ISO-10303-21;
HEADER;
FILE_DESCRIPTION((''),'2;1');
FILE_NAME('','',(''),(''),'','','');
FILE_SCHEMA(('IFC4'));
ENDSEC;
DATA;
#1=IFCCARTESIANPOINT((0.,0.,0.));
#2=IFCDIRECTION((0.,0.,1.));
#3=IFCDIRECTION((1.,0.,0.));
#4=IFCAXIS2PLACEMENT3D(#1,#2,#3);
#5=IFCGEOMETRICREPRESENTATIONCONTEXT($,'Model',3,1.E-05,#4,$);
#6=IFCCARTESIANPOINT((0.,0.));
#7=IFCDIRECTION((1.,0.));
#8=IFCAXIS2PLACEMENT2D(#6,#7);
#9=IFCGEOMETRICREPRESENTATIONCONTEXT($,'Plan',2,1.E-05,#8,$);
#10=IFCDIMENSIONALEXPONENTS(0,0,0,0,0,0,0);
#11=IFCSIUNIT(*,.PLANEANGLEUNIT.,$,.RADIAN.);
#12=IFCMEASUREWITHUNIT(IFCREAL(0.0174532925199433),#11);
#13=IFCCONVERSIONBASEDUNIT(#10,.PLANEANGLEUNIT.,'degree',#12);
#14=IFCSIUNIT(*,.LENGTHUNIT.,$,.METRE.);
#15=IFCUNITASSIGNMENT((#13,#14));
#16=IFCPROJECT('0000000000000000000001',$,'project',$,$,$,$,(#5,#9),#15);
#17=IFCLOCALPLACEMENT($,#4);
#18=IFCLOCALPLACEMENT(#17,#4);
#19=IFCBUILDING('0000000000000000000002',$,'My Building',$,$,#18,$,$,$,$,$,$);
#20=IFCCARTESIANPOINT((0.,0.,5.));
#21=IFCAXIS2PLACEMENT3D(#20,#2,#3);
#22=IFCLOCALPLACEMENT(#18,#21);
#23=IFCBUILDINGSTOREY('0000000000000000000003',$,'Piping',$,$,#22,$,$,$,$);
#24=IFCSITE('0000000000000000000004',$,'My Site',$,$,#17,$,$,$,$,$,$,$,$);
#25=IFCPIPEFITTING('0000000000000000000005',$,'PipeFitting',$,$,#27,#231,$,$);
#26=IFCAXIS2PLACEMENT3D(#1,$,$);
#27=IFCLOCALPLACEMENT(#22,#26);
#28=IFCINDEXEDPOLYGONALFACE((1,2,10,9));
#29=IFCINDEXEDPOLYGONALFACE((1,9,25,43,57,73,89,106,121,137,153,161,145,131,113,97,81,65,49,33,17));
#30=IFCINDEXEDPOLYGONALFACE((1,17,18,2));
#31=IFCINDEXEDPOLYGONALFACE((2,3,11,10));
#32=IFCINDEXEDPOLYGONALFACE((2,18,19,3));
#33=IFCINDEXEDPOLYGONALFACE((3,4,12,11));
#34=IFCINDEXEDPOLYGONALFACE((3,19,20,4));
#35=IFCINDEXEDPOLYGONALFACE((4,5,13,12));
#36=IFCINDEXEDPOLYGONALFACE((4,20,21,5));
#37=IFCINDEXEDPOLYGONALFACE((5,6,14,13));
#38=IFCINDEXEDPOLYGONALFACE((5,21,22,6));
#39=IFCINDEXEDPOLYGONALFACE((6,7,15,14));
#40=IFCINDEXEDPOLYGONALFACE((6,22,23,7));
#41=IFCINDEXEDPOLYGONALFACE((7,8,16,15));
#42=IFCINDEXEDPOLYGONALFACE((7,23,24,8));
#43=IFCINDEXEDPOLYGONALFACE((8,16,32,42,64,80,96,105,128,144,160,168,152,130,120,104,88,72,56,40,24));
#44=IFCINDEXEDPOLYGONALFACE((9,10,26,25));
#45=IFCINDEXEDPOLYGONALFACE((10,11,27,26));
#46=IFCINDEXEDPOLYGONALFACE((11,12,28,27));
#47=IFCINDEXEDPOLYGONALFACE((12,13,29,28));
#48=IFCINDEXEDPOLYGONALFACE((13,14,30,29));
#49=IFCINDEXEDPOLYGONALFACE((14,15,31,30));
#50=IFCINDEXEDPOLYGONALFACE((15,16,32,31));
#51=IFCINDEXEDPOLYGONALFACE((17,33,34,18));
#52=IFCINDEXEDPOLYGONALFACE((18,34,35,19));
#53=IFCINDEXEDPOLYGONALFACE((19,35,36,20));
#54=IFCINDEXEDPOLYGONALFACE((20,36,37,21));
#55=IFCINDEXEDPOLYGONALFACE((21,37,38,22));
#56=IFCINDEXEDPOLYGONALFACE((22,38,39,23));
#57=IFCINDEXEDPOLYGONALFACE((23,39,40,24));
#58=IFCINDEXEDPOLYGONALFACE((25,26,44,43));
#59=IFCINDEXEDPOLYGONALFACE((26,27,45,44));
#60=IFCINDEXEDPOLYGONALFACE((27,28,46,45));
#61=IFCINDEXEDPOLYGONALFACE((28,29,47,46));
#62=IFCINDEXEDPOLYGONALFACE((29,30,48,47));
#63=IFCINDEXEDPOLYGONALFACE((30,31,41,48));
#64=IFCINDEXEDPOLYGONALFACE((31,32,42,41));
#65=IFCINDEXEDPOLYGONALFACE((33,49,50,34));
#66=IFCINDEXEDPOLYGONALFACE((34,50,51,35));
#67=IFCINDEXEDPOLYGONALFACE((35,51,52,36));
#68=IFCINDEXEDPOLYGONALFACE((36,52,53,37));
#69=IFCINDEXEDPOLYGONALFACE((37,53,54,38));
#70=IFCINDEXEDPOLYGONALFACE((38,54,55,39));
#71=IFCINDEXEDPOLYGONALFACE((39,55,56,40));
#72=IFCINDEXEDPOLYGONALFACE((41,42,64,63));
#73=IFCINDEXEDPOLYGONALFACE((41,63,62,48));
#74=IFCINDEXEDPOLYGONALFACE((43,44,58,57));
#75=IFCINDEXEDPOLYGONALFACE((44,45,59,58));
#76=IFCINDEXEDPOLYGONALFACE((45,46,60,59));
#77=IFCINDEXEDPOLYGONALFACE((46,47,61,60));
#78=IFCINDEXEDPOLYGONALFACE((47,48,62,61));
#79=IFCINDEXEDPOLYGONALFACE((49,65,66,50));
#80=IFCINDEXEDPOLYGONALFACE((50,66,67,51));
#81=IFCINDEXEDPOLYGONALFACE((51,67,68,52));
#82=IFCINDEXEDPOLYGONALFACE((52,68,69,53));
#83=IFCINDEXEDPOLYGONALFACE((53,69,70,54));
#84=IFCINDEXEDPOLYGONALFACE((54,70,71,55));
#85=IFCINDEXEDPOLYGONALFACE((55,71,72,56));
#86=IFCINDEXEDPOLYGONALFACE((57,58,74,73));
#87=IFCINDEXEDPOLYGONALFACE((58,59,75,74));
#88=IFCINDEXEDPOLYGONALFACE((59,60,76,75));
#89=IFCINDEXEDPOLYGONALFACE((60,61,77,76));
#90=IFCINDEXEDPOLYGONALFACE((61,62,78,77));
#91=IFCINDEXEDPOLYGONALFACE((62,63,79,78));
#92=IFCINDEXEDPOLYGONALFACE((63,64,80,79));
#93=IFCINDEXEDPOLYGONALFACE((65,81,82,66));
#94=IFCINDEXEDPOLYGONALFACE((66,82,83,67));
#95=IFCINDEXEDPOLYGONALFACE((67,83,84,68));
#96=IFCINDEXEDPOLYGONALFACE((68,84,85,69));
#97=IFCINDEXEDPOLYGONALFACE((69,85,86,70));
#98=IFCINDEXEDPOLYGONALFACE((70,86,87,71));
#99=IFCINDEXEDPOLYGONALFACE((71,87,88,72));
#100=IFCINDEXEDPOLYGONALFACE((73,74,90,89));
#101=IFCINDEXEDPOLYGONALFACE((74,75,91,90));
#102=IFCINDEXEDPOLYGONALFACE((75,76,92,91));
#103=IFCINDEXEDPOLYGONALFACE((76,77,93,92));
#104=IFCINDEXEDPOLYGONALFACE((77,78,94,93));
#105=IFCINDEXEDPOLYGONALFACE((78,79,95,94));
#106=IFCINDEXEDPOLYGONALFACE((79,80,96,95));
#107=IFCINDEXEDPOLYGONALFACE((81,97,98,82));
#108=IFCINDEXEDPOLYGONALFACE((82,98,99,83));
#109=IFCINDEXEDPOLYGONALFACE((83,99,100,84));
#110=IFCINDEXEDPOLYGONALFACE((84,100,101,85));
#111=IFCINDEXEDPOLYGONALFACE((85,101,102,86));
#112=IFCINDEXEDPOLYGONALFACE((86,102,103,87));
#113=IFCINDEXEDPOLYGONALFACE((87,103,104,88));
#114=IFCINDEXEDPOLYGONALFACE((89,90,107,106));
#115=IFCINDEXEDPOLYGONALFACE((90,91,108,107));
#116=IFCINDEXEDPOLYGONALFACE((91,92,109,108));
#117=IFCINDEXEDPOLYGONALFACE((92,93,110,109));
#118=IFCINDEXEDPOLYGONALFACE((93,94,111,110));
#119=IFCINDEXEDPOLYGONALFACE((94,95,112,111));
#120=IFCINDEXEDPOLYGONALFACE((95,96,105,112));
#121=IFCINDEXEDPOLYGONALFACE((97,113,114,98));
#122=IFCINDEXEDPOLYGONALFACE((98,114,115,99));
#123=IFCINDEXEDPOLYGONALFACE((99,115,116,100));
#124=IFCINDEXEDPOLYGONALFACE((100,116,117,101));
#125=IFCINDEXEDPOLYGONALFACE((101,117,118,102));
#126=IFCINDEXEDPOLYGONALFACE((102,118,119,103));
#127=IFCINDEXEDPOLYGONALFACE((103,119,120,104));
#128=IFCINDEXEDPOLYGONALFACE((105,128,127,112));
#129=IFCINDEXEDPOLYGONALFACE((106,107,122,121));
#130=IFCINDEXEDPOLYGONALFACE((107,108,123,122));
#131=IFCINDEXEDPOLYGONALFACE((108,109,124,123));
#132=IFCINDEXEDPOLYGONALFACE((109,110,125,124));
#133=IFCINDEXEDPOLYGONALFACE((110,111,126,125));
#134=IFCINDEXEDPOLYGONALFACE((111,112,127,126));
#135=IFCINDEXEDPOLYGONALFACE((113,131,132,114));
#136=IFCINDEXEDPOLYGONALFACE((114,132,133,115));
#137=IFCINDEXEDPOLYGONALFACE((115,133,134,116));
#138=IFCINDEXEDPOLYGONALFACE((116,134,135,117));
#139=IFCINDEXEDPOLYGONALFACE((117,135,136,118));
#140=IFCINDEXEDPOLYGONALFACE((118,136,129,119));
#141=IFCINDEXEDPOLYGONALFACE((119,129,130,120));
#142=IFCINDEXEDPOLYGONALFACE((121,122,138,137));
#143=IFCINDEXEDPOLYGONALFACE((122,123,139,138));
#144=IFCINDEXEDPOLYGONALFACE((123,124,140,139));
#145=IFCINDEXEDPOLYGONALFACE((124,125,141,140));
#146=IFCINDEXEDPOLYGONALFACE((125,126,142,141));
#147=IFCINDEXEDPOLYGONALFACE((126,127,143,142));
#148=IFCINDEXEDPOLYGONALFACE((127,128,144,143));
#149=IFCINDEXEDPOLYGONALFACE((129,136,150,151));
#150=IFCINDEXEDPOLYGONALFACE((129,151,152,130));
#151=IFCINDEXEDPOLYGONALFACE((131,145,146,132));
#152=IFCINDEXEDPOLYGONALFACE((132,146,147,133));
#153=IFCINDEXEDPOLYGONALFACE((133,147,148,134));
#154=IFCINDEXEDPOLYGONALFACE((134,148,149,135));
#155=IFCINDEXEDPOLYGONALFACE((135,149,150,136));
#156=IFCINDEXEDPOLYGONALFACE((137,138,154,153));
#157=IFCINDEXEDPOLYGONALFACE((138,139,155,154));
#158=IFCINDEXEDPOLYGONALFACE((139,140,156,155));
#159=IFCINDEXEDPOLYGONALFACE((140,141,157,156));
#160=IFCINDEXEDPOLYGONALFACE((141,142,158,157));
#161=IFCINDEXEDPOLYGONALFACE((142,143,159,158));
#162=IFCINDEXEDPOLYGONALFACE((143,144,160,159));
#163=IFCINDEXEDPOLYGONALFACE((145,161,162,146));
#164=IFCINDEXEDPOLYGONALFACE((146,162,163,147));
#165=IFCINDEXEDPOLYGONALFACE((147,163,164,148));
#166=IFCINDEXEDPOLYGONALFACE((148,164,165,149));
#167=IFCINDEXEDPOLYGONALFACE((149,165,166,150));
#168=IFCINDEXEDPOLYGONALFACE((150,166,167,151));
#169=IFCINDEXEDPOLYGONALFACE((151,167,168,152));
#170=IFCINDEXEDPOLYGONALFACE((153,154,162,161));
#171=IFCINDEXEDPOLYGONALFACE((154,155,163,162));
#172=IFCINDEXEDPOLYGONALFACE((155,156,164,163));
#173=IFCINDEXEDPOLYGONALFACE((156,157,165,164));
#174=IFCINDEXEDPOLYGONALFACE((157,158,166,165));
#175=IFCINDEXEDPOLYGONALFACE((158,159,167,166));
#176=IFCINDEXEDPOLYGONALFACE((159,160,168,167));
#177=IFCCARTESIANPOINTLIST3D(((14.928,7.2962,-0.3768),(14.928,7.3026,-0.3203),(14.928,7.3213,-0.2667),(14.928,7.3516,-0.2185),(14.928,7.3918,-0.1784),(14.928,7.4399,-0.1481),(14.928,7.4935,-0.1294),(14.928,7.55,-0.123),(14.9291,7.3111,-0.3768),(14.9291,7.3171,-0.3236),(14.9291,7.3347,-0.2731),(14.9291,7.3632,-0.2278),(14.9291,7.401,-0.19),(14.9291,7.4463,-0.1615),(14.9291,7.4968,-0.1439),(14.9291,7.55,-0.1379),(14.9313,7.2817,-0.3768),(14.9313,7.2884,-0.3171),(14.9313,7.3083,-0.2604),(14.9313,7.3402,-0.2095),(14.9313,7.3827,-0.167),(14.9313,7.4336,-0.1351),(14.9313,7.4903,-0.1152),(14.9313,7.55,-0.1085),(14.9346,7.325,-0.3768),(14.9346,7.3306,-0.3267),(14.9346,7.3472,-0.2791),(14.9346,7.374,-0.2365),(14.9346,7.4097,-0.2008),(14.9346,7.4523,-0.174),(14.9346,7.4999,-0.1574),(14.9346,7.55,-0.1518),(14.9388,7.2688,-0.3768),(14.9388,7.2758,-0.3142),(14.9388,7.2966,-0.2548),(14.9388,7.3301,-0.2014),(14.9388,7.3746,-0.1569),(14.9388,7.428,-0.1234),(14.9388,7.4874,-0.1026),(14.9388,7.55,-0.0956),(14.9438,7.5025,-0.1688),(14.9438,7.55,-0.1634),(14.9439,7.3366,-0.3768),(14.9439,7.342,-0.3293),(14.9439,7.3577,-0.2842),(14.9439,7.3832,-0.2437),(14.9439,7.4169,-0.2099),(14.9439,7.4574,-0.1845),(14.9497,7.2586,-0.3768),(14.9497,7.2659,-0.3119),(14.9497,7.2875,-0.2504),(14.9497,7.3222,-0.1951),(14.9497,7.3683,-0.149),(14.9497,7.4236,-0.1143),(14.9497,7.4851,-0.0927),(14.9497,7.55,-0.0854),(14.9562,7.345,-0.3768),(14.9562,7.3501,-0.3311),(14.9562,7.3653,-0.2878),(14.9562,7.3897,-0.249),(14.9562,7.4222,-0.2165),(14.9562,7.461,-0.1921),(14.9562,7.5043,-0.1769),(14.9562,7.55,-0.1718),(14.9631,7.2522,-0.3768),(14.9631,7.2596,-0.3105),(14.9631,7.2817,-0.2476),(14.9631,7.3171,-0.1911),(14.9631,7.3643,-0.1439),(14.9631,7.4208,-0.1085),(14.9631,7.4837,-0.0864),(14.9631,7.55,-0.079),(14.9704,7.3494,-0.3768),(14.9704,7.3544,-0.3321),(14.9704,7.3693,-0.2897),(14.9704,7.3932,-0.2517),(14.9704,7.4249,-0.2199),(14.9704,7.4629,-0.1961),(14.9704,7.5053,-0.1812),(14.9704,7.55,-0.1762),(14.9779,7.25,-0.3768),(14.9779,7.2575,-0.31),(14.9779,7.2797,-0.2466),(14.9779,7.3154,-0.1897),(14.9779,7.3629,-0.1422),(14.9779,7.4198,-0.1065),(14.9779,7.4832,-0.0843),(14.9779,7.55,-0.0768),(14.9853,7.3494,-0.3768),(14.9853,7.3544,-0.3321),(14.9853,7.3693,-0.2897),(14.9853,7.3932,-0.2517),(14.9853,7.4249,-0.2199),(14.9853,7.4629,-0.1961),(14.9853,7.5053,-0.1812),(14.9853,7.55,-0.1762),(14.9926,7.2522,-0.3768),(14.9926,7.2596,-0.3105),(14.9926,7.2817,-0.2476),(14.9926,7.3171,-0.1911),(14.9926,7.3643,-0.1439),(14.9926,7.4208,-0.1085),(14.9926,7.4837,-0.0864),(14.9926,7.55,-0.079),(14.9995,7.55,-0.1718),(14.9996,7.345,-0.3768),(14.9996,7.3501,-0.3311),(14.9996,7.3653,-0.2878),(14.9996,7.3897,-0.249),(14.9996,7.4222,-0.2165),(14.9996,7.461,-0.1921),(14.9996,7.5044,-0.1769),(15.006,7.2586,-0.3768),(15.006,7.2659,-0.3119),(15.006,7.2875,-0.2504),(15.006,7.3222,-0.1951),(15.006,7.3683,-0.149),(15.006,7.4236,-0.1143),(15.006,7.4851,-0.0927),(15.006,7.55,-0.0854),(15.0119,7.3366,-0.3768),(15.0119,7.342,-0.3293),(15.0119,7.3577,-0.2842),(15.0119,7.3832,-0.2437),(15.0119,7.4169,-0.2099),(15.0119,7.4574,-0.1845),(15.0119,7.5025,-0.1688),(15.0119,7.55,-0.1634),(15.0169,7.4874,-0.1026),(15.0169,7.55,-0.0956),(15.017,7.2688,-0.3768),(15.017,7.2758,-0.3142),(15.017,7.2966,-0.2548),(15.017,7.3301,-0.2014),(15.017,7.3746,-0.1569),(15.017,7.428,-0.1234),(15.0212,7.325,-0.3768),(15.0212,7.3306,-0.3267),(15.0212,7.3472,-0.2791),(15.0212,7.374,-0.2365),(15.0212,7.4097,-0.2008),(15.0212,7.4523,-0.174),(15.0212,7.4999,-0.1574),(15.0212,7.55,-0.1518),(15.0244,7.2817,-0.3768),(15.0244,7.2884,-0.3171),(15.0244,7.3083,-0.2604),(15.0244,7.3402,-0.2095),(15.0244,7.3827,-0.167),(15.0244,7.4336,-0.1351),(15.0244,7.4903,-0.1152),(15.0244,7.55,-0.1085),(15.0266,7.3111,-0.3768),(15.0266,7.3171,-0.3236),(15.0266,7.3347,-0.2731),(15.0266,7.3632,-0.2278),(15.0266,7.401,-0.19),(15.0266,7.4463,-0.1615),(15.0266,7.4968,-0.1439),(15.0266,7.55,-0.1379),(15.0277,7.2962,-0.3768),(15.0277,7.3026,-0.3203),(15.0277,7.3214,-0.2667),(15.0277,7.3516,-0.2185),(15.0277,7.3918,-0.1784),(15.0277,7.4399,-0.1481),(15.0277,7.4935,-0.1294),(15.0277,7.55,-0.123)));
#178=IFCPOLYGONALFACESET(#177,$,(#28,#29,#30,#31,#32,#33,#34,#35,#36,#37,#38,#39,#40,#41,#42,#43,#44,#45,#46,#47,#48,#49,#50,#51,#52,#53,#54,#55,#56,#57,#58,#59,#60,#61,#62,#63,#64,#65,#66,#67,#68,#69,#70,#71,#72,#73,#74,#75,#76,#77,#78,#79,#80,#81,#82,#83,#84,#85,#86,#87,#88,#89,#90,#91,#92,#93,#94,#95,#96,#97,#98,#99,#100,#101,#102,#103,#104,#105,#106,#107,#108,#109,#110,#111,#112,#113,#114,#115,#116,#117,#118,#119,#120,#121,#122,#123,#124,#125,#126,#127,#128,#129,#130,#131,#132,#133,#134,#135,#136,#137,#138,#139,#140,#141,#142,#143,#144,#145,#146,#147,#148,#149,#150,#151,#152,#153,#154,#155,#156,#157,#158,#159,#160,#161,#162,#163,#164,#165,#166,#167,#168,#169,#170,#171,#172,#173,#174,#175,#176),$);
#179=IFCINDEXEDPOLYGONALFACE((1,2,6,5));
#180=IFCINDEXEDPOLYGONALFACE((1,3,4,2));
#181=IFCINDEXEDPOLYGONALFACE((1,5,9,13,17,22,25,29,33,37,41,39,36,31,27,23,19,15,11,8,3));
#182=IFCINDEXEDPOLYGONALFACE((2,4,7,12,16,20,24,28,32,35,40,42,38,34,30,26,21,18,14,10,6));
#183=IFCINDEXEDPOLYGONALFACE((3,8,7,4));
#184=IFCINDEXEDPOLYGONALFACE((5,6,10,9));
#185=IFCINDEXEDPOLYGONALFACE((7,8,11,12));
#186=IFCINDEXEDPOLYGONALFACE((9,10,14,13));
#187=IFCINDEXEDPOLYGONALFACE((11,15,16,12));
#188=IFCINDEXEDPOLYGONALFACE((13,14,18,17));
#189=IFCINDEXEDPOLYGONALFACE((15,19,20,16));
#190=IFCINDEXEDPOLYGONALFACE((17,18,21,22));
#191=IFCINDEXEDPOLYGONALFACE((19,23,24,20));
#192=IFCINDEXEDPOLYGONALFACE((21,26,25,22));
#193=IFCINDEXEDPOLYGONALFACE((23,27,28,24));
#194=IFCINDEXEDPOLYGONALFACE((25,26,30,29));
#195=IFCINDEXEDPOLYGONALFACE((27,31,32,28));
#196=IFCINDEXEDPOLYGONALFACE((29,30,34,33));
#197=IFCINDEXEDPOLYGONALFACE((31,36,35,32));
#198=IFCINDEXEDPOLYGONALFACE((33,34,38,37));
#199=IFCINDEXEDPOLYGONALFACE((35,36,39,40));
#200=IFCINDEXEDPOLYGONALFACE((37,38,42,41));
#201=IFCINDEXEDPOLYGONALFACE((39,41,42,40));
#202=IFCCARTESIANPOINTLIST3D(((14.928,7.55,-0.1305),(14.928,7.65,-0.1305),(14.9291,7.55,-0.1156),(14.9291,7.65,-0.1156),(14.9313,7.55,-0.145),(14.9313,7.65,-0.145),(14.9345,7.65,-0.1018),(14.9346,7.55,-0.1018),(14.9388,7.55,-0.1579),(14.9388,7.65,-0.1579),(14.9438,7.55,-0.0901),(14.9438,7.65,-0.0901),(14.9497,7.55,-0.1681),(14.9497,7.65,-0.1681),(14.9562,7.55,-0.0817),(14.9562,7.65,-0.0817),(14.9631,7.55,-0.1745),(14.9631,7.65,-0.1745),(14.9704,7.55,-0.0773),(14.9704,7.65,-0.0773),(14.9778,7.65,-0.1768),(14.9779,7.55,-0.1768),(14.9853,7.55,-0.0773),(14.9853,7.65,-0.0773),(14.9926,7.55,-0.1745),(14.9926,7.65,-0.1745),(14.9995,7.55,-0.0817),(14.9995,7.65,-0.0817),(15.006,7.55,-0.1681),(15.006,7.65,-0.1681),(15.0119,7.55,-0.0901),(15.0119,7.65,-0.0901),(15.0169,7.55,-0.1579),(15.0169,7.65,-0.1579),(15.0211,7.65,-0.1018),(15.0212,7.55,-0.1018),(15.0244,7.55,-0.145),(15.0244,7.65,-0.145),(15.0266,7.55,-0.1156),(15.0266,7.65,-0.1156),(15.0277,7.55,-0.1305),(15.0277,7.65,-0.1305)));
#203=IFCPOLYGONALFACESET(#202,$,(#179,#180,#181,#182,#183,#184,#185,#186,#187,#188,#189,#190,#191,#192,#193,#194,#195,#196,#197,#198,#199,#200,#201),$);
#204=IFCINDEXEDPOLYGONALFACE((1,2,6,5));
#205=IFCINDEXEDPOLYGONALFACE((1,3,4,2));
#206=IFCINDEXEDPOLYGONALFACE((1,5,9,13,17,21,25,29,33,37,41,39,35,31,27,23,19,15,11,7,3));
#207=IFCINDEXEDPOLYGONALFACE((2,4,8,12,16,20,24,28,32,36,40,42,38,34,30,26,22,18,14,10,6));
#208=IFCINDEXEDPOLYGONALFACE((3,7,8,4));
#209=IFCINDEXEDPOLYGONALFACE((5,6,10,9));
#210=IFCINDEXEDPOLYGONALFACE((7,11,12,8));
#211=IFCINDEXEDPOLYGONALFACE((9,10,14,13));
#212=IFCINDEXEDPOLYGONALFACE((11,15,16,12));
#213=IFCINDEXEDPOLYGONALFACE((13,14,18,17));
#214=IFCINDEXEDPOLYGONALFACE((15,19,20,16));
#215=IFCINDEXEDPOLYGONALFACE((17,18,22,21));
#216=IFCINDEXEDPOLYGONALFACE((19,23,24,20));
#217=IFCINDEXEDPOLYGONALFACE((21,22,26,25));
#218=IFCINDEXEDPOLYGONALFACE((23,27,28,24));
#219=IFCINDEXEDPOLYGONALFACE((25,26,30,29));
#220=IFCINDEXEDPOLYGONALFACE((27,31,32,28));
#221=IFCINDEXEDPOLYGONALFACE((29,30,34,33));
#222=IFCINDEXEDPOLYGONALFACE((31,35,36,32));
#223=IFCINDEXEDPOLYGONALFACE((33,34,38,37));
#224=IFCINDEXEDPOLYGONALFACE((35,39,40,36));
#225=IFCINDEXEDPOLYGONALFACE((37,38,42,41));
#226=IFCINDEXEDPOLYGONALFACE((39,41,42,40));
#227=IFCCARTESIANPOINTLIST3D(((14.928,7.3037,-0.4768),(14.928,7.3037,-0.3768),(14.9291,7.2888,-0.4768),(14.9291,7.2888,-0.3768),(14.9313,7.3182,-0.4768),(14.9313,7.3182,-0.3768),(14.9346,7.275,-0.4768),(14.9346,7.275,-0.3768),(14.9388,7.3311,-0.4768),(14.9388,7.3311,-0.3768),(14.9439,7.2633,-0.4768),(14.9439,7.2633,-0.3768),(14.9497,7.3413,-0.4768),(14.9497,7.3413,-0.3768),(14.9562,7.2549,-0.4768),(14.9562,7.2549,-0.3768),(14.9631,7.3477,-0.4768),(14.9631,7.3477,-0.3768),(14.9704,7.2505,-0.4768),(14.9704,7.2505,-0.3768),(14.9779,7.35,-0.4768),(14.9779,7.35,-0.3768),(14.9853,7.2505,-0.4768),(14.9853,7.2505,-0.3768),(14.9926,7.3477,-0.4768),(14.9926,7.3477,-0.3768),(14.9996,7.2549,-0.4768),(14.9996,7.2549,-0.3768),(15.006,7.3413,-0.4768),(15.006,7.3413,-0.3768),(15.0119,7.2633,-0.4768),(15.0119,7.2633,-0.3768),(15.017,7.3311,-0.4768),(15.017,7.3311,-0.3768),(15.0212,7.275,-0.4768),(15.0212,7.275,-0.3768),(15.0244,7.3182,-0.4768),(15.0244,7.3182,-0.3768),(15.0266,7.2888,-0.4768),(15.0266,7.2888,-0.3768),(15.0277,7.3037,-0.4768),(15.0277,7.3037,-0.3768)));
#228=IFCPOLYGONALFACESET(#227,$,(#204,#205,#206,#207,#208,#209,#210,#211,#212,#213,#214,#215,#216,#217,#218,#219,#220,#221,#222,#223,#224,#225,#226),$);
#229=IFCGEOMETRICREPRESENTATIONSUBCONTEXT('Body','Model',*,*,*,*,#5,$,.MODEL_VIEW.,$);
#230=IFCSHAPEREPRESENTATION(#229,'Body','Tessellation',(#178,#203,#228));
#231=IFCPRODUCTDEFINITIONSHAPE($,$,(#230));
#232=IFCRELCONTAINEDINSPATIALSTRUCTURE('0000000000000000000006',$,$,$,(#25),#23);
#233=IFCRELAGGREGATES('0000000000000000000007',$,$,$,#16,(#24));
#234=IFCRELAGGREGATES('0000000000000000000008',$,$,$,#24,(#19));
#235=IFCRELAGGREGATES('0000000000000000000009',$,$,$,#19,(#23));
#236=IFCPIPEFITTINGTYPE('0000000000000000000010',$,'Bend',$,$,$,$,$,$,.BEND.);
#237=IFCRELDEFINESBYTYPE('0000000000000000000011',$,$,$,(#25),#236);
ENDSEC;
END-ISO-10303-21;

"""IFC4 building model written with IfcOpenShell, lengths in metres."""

from ifc_helpers import new_model, entity, si_unit, converted_unit, frame, origin_with_axes, origin_2d_with_axis, place, context, subcontext, project, spatial, circle, extrude, source, transform, mapped, type_object, type_shapes, element, save


model = new_model("IFC4")

# Units and contexts
model_context = context("Model", 3, precision=1e-05, world=origin_with_axes())
plan_context = context("Plan", 2, precision=1e-05, world=origin_2d_with_axis())
body_context = subcontext(model_context, "Body", "Model", "MODEL_VIEW")
ifc_project = project(units=[converted_unit("PLANEANGLEUNIT", "degree", entity("IfcReal", 0.0174532925199433), si_unit("PLANEANGLEUNIT", "RADIAN"), dimensions=[0, 0, 0, 0, 0, 0, 0]), si_unit("LENGTHUNIT", "METRE")], contexts=[model_context, plan_context])

# Site, building, storey
site_placement = place(None, origin_with_axes())
site = spatial("IfcSite", under=ifc_project, at=site_placement, Name="My Site")
building_placement = place(site_placement, origin_with_axes())
building = spatial("IfcBuilding", under=site, at=building_placement, Name="My Building")
storey_placement = place(building_placement, frame((0.0, 0.0, 5.0), z_axis=(0.0, 0.0, 1.0), x_axis=(1.0, 0.0, 0.0)))
storey = spatial("IfcBuildingStorey", under=building, at=storey_placement, Name="Piping")

# Pipe fitting
pipe_fitting_type_1 = type_object("IfcPipeFittingType", Name="Bend", PredefinedType="BEND")
shared_shape = source(origin_with_axes(), body_context, "Body", "SolidModel", [
    entity("IfcSweptDiskSolid", entity("IfcIndexedPolyCurve", entity("IfcCartesianPointList3D", [[0.0, 0.0, -0.1], [0.0732, 0.0, -0.2768], [0.25, 0.0, -0.35]]), [entity("IfcArcIndex", [1, 2, 3])]), 0.05),
    extrude(circle(Radius=0.05), origin_with_axes(), (0.0, 0.0, -1.0), 0.1),
    extrude(circle(Radius=0.05), frame((0.25, 0.0, -0.35), z_axis=(1.0, 0.0, 0.0), x_axis=(0.0, 0.0, 1.0)), (0.0, 0.0, 1.0), 0.1),
])
type_shapes(pipe_fitting_type_1, [shared_shape])
for number, where, z_axis, x_axis, name in (
    (1, (14.9778, 7.65, -0.1268), (-0.00006, 1.0, 0.0), (0.0, 0.0, -1.0), "PipeFitting"),
):
    element("IfcPipeFitting", number, at=place(storey_placement, frame(where, z_axis=z_axis, x_axis=x_axis)), inside=storey, type_object=pipe_fitting_type_1, Name=name, context=body_context, shape_type="MappedRepresentation", body=[
        mapped(shared_shape, transform((0.0, 0.0, 0.0), x_axis=(1.0, 0.0, 0.0), y_axis=(0.0, 1.0, 0.0), z_axis=(0.0, 0.0, 1.0), scale=1.0)),
    ])

save(model, "model.ifc")
